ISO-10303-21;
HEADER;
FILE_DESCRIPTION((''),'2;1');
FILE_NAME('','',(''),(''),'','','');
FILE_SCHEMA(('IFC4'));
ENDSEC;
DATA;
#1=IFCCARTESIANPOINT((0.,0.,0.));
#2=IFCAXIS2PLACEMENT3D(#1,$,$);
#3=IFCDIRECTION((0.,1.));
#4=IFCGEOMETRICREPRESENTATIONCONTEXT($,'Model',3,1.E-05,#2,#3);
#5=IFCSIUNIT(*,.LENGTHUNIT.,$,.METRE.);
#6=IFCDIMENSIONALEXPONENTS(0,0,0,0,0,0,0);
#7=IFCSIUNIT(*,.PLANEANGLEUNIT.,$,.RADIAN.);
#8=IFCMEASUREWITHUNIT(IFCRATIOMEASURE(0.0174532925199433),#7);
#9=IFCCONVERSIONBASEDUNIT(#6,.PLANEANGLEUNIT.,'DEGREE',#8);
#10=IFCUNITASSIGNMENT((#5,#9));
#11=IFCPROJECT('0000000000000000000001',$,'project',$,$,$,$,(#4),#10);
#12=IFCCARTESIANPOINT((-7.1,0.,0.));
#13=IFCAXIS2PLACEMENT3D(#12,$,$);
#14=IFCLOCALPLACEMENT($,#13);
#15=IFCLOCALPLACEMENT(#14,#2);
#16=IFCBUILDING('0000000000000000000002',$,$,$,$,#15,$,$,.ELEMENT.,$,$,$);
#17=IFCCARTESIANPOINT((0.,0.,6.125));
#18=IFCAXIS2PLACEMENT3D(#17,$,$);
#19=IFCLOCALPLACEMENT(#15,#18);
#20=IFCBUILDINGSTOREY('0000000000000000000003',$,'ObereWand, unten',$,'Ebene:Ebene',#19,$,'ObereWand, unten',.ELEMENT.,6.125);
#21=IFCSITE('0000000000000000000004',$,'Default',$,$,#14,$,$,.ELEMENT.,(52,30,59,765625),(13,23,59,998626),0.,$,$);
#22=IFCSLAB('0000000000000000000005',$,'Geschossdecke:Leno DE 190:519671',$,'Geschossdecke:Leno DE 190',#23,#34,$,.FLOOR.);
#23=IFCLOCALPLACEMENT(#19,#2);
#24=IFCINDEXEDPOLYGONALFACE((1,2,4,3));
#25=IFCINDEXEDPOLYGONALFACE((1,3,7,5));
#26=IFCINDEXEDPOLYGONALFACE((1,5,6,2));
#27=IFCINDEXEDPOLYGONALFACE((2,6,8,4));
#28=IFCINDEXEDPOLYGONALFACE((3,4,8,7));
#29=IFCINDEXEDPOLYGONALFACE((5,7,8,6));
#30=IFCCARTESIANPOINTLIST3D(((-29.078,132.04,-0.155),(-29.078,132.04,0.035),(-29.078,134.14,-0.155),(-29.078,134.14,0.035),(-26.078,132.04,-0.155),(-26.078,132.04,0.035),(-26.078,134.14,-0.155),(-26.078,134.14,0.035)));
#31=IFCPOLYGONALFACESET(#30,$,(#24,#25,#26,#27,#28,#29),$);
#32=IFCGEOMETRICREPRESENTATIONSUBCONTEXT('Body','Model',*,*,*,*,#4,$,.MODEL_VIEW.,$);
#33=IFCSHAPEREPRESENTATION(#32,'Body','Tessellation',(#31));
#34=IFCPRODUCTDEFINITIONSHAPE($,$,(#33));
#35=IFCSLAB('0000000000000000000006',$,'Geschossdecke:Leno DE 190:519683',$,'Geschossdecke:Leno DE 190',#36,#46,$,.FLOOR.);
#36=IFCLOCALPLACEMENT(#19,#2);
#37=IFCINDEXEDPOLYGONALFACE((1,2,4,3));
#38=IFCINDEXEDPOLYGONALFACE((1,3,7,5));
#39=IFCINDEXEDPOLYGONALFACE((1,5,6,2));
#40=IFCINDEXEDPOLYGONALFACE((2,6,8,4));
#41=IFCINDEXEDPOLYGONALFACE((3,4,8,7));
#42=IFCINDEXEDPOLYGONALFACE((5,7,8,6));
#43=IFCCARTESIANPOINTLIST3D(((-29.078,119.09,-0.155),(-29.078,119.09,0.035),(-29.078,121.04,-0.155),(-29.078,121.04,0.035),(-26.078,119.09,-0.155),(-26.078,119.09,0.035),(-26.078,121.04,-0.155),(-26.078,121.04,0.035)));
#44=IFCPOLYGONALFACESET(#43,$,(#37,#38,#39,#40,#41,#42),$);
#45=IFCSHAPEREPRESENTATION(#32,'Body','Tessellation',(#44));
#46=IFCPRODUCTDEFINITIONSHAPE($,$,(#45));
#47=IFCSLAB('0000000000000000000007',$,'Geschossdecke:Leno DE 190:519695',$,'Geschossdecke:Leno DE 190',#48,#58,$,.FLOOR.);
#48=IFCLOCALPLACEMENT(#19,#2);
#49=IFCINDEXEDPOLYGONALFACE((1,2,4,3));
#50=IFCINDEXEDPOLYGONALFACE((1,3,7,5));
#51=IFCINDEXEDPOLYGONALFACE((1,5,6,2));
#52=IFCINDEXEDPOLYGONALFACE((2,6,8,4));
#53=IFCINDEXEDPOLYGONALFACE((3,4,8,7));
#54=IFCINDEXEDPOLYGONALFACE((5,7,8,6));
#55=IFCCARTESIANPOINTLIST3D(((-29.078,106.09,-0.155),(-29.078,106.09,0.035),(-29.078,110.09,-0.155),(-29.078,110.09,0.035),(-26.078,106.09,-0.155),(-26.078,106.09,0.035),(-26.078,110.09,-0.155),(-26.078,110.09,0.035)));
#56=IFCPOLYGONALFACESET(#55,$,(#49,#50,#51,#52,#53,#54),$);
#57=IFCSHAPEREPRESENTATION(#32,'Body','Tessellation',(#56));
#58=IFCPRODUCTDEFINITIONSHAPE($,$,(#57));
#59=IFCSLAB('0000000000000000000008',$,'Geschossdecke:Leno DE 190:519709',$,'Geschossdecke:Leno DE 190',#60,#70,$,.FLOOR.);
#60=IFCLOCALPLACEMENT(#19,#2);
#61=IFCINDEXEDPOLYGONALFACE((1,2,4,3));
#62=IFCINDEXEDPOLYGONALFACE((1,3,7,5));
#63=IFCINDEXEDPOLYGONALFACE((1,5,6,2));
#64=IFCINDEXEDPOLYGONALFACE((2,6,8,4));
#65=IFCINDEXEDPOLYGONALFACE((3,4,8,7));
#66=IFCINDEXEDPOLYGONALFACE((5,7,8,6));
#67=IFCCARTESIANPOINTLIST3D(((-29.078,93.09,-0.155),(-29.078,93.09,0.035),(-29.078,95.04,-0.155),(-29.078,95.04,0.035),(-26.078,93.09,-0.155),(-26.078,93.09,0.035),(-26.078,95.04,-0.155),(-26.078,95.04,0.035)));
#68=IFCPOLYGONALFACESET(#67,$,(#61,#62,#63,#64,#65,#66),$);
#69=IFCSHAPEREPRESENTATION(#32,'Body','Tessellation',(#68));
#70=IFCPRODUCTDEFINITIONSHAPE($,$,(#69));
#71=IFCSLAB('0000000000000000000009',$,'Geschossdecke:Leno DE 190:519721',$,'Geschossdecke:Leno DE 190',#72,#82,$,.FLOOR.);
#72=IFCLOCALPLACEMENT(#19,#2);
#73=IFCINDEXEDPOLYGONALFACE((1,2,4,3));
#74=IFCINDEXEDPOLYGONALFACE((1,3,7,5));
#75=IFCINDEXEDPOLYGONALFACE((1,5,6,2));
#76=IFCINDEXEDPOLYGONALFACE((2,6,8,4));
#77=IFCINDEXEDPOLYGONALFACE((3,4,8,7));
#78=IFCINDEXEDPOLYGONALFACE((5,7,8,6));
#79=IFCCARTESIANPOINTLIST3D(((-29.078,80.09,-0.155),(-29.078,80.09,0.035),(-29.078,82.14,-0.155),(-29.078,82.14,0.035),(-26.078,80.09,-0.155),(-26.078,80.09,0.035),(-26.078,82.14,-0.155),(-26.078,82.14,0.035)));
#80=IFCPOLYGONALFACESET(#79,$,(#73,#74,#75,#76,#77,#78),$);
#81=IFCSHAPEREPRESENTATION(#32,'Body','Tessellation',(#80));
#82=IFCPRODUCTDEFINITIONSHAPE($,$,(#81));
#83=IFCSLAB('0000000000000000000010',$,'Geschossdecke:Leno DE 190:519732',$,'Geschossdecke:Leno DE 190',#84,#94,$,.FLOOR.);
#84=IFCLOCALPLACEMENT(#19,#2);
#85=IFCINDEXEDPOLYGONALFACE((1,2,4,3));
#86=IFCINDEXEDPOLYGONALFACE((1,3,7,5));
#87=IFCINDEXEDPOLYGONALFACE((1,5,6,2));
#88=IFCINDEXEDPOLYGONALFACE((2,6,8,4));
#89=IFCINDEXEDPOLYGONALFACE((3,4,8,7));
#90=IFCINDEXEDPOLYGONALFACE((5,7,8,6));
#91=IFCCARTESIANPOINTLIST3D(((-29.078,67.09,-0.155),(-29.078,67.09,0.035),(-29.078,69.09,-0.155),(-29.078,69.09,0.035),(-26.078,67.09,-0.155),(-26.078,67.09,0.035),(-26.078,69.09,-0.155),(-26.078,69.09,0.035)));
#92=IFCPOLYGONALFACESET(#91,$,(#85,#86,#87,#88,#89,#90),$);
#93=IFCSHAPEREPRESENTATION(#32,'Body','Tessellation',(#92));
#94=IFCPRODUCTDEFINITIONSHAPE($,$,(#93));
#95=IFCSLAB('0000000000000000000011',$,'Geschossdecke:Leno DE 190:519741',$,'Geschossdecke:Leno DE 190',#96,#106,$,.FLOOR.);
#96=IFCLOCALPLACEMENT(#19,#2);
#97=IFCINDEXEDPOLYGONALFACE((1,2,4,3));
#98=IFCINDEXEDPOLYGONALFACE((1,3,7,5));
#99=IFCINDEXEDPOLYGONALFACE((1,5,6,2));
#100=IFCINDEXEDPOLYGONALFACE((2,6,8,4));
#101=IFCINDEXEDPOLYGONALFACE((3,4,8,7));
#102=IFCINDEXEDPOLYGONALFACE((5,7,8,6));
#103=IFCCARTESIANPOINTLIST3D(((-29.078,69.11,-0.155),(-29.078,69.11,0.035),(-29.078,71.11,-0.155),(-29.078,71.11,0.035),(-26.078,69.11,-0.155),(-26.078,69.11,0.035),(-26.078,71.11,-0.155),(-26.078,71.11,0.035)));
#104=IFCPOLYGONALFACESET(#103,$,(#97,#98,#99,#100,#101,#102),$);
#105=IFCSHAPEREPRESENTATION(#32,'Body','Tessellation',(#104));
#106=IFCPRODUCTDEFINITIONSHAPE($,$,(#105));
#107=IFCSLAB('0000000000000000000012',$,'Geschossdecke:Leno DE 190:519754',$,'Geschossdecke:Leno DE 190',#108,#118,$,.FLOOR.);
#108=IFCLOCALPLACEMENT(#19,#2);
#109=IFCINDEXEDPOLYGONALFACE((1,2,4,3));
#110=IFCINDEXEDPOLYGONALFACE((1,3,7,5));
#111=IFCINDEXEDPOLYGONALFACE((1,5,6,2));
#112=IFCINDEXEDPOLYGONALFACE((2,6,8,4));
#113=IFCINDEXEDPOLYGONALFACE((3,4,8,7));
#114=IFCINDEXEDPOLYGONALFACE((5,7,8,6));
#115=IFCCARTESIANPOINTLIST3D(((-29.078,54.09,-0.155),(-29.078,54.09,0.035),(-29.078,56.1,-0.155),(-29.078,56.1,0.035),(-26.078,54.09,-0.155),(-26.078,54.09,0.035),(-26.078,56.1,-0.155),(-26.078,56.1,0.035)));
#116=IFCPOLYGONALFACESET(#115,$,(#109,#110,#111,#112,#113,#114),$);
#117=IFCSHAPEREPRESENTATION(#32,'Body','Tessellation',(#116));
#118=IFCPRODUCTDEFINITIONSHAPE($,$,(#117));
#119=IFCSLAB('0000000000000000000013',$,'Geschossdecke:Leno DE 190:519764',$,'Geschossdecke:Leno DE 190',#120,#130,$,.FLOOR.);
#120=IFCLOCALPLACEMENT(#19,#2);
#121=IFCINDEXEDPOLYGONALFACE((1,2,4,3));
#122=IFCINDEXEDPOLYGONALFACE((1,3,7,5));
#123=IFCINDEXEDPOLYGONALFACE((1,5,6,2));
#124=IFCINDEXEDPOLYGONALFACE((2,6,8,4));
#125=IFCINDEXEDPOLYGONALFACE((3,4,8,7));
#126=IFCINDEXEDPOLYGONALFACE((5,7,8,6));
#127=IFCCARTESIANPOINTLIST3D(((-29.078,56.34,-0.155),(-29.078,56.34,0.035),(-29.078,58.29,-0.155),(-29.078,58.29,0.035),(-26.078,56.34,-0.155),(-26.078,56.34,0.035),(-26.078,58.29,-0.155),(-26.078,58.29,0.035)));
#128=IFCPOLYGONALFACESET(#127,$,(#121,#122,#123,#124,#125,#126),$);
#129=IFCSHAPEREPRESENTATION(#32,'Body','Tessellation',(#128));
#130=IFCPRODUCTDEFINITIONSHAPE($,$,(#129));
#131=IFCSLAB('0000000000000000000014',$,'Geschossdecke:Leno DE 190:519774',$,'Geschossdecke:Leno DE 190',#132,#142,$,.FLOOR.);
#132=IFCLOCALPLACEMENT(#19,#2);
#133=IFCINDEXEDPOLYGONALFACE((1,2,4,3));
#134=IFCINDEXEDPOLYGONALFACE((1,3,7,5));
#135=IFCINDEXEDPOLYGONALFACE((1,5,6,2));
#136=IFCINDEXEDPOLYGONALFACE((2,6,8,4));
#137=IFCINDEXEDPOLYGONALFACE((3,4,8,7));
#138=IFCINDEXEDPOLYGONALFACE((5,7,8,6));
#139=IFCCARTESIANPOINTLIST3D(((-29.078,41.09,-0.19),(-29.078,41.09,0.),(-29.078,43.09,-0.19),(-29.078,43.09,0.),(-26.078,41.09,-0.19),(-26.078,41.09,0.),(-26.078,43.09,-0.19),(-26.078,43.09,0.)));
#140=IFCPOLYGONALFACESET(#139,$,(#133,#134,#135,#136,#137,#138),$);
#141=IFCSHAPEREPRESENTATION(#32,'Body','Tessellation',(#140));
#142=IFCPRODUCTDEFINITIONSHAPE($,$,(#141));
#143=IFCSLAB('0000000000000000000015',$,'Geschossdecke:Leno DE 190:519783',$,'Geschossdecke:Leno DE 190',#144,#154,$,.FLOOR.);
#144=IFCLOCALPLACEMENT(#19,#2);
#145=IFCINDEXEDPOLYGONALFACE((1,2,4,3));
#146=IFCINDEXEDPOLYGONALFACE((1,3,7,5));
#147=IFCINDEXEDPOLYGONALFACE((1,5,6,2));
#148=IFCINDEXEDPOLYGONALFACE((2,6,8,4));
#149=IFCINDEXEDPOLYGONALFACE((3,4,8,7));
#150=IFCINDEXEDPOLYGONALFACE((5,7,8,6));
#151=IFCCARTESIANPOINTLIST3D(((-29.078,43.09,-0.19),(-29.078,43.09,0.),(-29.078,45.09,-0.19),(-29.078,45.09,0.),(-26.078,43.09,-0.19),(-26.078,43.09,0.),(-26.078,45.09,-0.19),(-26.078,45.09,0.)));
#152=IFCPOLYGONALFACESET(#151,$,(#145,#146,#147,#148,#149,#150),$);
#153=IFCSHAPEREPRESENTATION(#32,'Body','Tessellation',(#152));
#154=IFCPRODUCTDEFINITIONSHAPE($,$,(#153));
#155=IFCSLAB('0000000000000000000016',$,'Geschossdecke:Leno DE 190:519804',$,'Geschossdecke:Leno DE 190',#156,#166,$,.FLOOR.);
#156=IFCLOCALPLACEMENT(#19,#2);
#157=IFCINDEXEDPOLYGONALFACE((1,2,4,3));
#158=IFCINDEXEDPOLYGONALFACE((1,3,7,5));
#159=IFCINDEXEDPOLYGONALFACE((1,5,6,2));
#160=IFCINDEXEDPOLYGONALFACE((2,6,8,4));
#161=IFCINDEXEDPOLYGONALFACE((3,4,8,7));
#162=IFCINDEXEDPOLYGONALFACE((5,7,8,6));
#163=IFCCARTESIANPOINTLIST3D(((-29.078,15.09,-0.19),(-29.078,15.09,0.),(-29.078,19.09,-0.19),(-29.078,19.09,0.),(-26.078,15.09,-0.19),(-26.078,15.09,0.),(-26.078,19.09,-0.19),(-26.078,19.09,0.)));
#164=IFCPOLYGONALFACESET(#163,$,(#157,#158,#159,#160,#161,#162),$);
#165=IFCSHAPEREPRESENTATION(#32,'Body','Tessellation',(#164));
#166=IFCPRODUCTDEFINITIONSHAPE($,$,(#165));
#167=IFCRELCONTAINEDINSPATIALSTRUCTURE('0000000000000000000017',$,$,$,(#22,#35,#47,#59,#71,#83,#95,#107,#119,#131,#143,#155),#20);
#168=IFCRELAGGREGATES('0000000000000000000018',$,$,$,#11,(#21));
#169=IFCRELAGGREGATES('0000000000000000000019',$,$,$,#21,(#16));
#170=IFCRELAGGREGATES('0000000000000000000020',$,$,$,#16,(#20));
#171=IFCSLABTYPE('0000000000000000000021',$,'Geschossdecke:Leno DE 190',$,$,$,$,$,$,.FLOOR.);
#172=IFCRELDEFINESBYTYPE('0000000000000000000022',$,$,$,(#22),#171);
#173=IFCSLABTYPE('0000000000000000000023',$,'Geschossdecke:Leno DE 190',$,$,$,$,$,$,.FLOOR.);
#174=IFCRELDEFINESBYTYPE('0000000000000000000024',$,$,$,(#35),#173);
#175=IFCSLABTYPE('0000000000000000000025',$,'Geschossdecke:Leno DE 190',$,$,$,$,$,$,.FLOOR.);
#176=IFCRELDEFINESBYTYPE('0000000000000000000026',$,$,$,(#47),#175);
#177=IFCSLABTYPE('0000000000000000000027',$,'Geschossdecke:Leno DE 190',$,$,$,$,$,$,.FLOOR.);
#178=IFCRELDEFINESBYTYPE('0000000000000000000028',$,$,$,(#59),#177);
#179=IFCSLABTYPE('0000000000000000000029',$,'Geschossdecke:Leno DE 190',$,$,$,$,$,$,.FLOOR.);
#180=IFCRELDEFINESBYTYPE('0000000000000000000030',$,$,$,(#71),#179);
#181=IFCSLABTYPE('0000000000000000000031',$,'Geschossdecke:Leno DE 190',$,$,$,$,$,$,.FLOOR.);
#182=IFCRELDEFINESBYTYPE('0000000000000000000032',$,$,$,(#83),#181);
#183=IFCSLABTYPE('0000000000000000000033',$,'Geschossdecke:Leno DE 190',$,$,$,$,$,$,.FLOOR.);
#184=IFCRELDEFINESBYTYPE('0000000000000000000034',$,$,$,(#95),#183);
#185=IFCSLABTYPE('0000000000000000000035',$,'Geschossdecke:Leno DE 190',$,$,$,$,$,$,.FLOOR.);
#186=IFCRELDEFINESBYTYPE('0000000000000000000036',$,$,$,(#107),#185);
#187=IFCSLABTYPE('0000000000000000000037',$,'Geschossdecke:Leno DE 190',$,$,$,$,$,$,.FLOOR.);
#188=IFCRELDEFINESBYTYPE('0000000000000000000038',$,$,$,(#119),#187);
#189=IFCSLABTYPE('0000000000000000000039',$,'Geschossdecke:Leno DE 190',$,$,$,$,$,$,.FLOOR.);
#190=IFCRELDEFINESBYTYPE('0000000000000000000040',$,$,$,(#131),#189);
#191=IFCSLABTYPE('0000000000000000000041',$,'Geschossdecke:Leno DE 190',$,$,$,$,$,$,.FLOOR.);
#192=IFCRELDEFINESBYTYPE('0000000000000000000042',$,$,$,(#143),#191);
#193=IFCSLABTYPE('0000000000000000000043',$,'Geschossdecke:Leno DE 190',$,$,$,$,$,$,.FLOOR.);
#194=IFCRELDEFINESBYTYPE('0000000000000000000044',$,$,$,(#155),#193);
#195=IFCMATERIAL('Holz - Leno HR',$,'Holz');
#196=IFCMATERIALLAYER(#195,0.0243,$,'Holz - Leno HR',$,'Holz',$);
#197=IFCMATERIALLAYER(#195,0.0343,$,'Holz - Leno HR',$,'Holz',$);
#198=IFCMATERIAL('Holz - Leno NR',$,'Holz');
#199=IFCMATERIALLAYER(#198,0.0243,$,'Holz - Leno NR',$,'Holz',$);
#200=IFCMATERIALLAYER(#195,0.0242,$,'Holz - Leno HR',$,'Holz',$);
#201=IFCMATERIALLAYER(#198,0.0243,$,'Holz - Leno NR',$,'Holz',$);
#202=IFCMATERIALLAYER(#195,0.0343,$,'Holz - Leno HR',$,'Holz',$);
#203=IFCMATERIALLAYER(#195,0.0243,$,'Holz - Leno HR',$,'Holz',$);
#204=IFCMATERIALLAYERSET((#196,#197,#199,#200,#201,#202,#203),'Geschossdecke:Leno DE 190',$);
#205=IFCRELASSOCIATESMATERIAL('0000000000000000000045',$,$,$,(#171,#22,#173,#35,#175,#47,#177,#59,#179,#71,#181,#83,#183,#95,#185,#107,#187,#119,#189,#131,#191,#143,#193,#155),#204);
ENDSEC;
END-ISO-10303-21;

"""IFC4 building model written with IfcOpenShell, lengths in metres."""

from ifc_helpers import new_model, entity, si_unit, converted_unit, direction, frame, origin, place, context, subcontext, project, spatial, indexed_curve, outline, extrude, material, layer, layer_set, type_object, element, save


model = new_model("IFC4")

# Units and contexts
model_context = context("Model", 3, precision=1e-05, world=origin(), true_north=direction((0.0, 1.0)))
body_context = subcontext(model_context, "Body", "Model", "MODEL_VIEW")
ifc_project = project(units=[si_unit("LENGTHUNIT", "METRE"), converted_unit("PLANEANGLEUNIT", "DEGREE", entity("IfcRatioMeasure", 0.0174532925199433), si_unit("PLANEANGLEUNIT", "RADIAN"), dimensions=[0, 0, 0, 0, 0, 0, 0])], contexts=[model_context])

# Site, building, storey
site_placement = place(None, frame((-7.1, 0.0, 0.0)))
site = spatial("IfcSite", under=ifc_project, at=site_placement, Name="Default", CompositionType="ELEMENT", RefLatitude=(52, 30, 59, 765625), RefLongitude=(13, 23, 59, 998626), RefElevation=0.0)
building_placement = place(site_placement, origin())
building = spatial("IfcBuilding", under=site, at=building_placement, CompositionType="ELEMENT")
storey_placement = place(building_placement, frame((0.0, 0.0, 6.125)))
storey = spatial("IfcBuildingStorey", under=building, at=storey_placement, Name="ObereWand, unten", ObjectType="Ebene:Ebene", LongName="ObereWand, unten", CompositionType="ELEMENT", Elevation=6.125)

# Slabs
ifc_material_1 = material(Name="Holz - Leno HR", Category="Holz")
ifc_layer_1 = layer(ifc_material_1, 0.0243, Name="Holz - Leno HR", Category="Holz")
ifc_layer_2 = layer(ifc_material_1, 0.0343, Name="Holz - Leno HR", Category="Holz")
ifc_material_2 = material(Name="Holz - Leno NR", Category="Holz")
ifc_layer_3 = layer(ifc_material_2, 0.0243, Name="Holz - Leno NR", Category="Holz")
ifc_layer_4 = layer(ifc_material_1, 0.0242, Name="Holz - Leno HR", Category="Holz")
ifc_layer_5 = layer(ifc_material_2, 0.0243, Name="Holz - Leno NR", Category="Holz")
ifc_layer_6 = layer(ifc_material_1, 0.0343, Name="Holz - Leno HR", Category="Holz")
ifc_layer_7 = layer(ifc_material_1, 0.0243, Name="Holz - Leno HR", Category="Holz")
ifc_layer_set_1 = layer_set([ifc_layer_1, ifc_layer_2, ifc_layer_3, ifc_layer_4, ifc_layer_5, ifc_layer_6, ifc_layer_7], Name="Geschossdecke:Leno DE 190")
slab_type_1 = type_object("IfcSlabType", Name="Geschossdecke:Leno DE 190", PredefinedType="FLOOR", material=ifc_layer_set_1)
slab_1_placement = place(storey_placement, origin())
element("IfcSlab", 1, at=slab_1_placement, inside=storey, type_object=slab_type_1, material=ifc_layer_set_1, Name="Geschossdecke:Leno DE 190:519671", ObjectType="Geschossdecke:Leno DE 190", PredefinedType="FLOOR", context=body_context, shape_type="SweptSolid", body=[
    extrude(outline(indexed_curve([(-1.05, -1.5), (1.05, -1.5), (1.05, 1.5), (-1.05, 1.5), (-1.05, -1.5)], self_intersect=False)), frame((-27.578, 133.09, 0.035), z_axis=(0.0, 0.0, -1.0), x_axis=(0.0, 1.0, 0.0)), (0.0, 0.0, 1.0), 0.19),
])
slab_type_2 = type_object("IfcSlabType", Name="Geschossdecke:Leno DE 190", PredefinedType="FLOOR", material=ifc_layer_set_1)
slab_2_placement = place(storey_placement, origin())
element("IfcSlab", 2, at=slab_2_placement, inside=storey, type_object=slab_type_2, material=ifc_layer_set_1, Name="Geschossdecke:Leno DE 190:519683", ObjectType="Geschossdecke:Leno DE 190", PredefinedType="FLOOR", context=body_context, shape_type="SweptSolid", body=[
    extrude(outline(indexed_curve([(-0.975, -1.5), (0.975, -1.5), (0.975, 1.5), (-0.975, 1.5), (-0.975, -1.5)], self_intersect=False)), frame((-27.578, 120.065, 0.035), z_axis=(0.0, 0.0, -1.0), x_axis=(0.0, 1.0, 0.0)), (0.0, 0.0, 1.0), 0.19),
])
slab_type_3 = type_object("IfcSlabType", Name="Geschossdecke:Leno DE 190", PredefinedType="FLOOR", material=ifc_layer_set_1)
slab_3_placement = place(storey_placement, origin())
element("IfcSlab", 3, at=slab_3_placement, inside=storey, type_object=slab_type_3, material=ifc_layer_set_1, Name="Geschossdecke:Leno DE 190:519695", ObjectType="Geschossdecke:Leno DE 190", PredefinedType="FLOOR", context=body_context, shape_type="SweptSolid", body=[
    extrude(outline(indexed_curve([(-2.0, -1.5), (2.0, -1.5), (2.0, 1.5), (-2.0, 1.5), (-2.0, -1.5)], self_intersect=False)), frame((-27.578, 108.09, 0.035), z_axis=(0.0, 0.0, -1.0), x_axis=(0.0, 1.0, 0.0)), (0.0, 0.0, 1.0), 0.19),
])
slab_type_4 = type_object("IfcSlabType", Name="Geschossdecke:Leno DE 190", PredefinedType="FLOOR", material=ifc_layer_set_1)
slab_4_placement = place(storey_placement, origin())
element("IfcSlab", 4, at=slab_4_placement, inside=storey, type_object=slab_type_4, material=ifc_layer_set_1, Name="Geschossdecke:Leno DE 190:519709", ObjectType="Geschossdecke:Leno DE 190", PredefinedType="FLOOR", context=body_context, shape_type="SweptSolid", body=[
    extrude(outline(indexed_curve([(-0.975, -1.5), (0.975, -1.5), (0.975, 1.5), (-0.975, 1.5), (-0.975, -1.5)], self_intersect=False)), frame((-27.578, 94.065, 0.035), z_axis=(0.0, 0.0, -1.0), x_axis=(0.0, 1.0, 0.0)), (0.0, 0.0, 1.0), 0.19),
])
slab_type_5 = type_object("IfcSlabType", Name="Geschossdecke:Leno DE 190", PredefinedType="FLOOR", material=ifc_layer_set_1)
slab_5_placement = place(storey_placement, origin())
element("IfcSlab", 5, at=slab_5_placement, inside=storey, type_object=slab_type_5, material=ifc_layer_set_1, Name="Geschossdecke:Leno DE 190:519721", ObjectType="Geschossdecke:Leno DE 190", PredefinedType="FLOOR", context=body_context, shape_type="SweptSolid", body=[
    extrude(outline(indexed_curve([(-1.025, -1.5), (1.025, -1.5), (1.025, 1.5), (-1.025, 1.5), (-1.025, -1.5)], self_intersect=False)), frame((-27.578, 81.115, 0.035), z_axis=(0.0, 0.0, -1.0), x_axis=(0.0, 1.0, 0.0)), (0.0, 0.0, 1.0), 0.19),
])
slab_type_6 = type_object("IfcSlabType", Name="Geschossdecke:Leno DE 190", PredefinedType="FLOOR", material=ifc_layer_set_1)
slab_6_placement = place(storey_placement, origin())
element("IfcSlab", 6, at=slab_6_placement, inside=storey, type_object=slab_type_6, material=ifc_layer_set_1, Name="Geschossdecke:Leno DE 190:519732", ObjectType="Geschossdecke:Leno DE 190", PredefinedType="FLOOR", context=body_context, shape_type="SweptSolid", body=[
    extrude(outline(indexed_curve([(-1.0, -1.5), (1.0, -1.5), (1.0, 1.5), (-1.0, 1.5), (-1.0, -1.5)], self_intersect=False)), frame((-27.578, 68.09, 0.035), z_axis=(0.0, 0.0, -1.0), x_axis=(0.0, 1.0, 0.0)), (0.0, 0.0, 1.0), 0.19),
])
slab_type_7 = type_object("IfcSlabType", Name="Geschossdecke:Leno DE 190", PredefinedType="FLOOR", material=ifc_layer_set_1)
slab_7_placement = place(storey_placement, origin())
element("IfcSlab", 7, at=slab_7_placement, inside=storey, type_object=slab_type_7, material=ifc_layer_set_1, Name="Geschossdecke:Leno DE 190:519741", ObjectType="Geschossdecke:Leno DE 190", PredefinedType="FLOOR", context=body_context, shape_type="SweptSolid", body=[
    extrude(outline(indexed_curve([(-1.0, -1.5), (1.0, -1.5), (1.0, 1.5), (-1.0, 1.5), (-1.0, -1.5)], self_intersect=False)), frame((-27.578, 70.11, 0.035), z_axis=(0.0, 0.0, -1.0), x_axis=(0.0, 1.0, 0.0)), (0.0, 0.0, 1.0), 0.19),
])
slab_type_8 = type_object("IfcSlabType", Name="Geschossdecke:Leno DE 190", PredefinedType="FLOOR", material=ifc_layer_set_1)
slab_8_placement = place(storey_placement, origin())
element("IfcSlab", 8, at=slab_8_placement, inside=storey, type_object=slab_type_8, material=ifc_layer_set_1, Name="Geschossdecke:Leno DE 190:519754", ObjectType="Geschossdecke:Leno DE 190", PredefinedType="FLOOR", context=body_context, shape_type="SweptSolid", body=[
    extrude(outline(indexed_curve([(-1.005, -1.5), (1.005, -1.5), (1.005, 1.5), (-1.005, 1.5), (-1.005, -1.5)], self_intersect=False)), frame((-27.578, 55.095, 0.035), z_axis=(0.0, 0.0, -1.0), x_axis=(0.0, 1.0, 0.0)), (0.0, 0.0, 1.0), 0.19),
])
slab_type_9 = type_object("IfcSlabType", Name="Geschossdecke:Leno DE 190", PredefinedType="FLOOR", material=ifc_layer_set_1)
slab_9_placement = place(storey_placement, origin())
element("IfcSlab", 9, at=slab_9_placement, inside=storey, type_object=slab_type_9, material=ifc_layer_set_1, Name="Geschossdecke:Leno DE 190:519764", ObjectType="Geschossdecke:Leno DE 190", PredefinedType="FLOOR", context=body_context, shape_type="SweptSolid", body=[
    extrude(outline(indexed_curve([(-0.975, -1.5), (0.975, -1.5), (0.975, 1.5), (-0.975, 1.5), (-0.975, -1.5)], self_intersect=False)), frame((-27.578, 57.315, 0.035), z_axis=(0.0, 0.0, -1.0), x_axis=(0.0, 1.0, 0.0)), (0.0, 0.0, 1.0), 0.19),
])
slab_type_10 = type_object("IfcSlabType", Name="Geschossdecke:Leno DE 190", PredefinedType="FLOOR", material=ifc_layer_set_1)
slab_10_placement = place(storey_placement, origin())
element("IfcSlab", 10, at=slab_10_placement, inside=storey, type_object=slab_type_10, material=ifc_layer_set_1, Name="Geschossdecke:Leno DE 190:519774", ObjectType="Geschossdecke:Leno DE 190", PredefinedType="FLOOR", context=body_context, shape_type="SweptSolid", body=[
    extrude(outline(indexed_curve([(-1.0, -1.5), (1.0, -1.5), (1.0, 1.5), (-1.0, 1.5), (-1.0, -1.5)], self_intersect=False)), frame((-27.578, 42.09, 0.0), z_axis=(0.0, 0.0, -1.0), x_axis=(0.0, 1.0, 0.0)), (0.0, 0.0, 1.0), 0.19),
])
slab_type_11 = type_object("IfcSlabType", Name="Geschossdecke:Leno DE 190", PredefinedType="FLOOR", material=ifc_layer_set_1)
slab_11_placement = place(storey_placement, origin())
element("IfcSlab", 11, at=slab_11_placement, inside=storey, type_object=slab_type_11, material=ifc_layer_set_1, Name="Geschossdecke:Leno DE 190:519783", ObjectType="Geschossdecke:Leno DE 190", PredefinedType="FLOOR", context=body_context, shape_type="SweptSolid", body=[
    extrude(outline(indexed_curve([(-1.0, -1.5), (1.0, -1.5), (1.0, 1.5), (-1.0, 1.5), (-1.0, -1.5)], self_intersect=False)), frame((-27.578, 44.09, 0.0), z_axis=(0.0, 0.0, -1.0), x_axis=(0.0, 1.0, 0.0)), (0.0, 0.0, 1.0), 0.19),
])
slab_type_12 = type_object("IfcSlabType", Name="Geschossdecke:Leno DE 190", PredefinedType="FLOOR", material=ifc_layer_set_1)
slab_12_placement = place(storey_placement, origin())
element("IfcSlab", 12, at=slab_12_placement, inside=storey, type_object=slab_type_12, material=ifc_layer_set_1, Name="Geschossdecke:Leno DE 190:519804", ObjectType="Geschossdecke:Leno DE 190", PredefinedType="FLOOR", context=body_context, shape_type="SweptSolid", body=[
    extrude(outline(indexed_curve([(-2.0, -1.5), (2.0, -1.5), (2.0, 1.5), (-2.0, 1.5), (-2.0, -1.5)], self_intersect=False)), frame((-27.578, 17.09, 0.0), z_axis=(0.0, 0.0, -1.0), x_axis=(0.0, 1.0, 0.0)), (0.0, 0.0, 1.0), 0.19),
])

save(model, "model.ifc")
